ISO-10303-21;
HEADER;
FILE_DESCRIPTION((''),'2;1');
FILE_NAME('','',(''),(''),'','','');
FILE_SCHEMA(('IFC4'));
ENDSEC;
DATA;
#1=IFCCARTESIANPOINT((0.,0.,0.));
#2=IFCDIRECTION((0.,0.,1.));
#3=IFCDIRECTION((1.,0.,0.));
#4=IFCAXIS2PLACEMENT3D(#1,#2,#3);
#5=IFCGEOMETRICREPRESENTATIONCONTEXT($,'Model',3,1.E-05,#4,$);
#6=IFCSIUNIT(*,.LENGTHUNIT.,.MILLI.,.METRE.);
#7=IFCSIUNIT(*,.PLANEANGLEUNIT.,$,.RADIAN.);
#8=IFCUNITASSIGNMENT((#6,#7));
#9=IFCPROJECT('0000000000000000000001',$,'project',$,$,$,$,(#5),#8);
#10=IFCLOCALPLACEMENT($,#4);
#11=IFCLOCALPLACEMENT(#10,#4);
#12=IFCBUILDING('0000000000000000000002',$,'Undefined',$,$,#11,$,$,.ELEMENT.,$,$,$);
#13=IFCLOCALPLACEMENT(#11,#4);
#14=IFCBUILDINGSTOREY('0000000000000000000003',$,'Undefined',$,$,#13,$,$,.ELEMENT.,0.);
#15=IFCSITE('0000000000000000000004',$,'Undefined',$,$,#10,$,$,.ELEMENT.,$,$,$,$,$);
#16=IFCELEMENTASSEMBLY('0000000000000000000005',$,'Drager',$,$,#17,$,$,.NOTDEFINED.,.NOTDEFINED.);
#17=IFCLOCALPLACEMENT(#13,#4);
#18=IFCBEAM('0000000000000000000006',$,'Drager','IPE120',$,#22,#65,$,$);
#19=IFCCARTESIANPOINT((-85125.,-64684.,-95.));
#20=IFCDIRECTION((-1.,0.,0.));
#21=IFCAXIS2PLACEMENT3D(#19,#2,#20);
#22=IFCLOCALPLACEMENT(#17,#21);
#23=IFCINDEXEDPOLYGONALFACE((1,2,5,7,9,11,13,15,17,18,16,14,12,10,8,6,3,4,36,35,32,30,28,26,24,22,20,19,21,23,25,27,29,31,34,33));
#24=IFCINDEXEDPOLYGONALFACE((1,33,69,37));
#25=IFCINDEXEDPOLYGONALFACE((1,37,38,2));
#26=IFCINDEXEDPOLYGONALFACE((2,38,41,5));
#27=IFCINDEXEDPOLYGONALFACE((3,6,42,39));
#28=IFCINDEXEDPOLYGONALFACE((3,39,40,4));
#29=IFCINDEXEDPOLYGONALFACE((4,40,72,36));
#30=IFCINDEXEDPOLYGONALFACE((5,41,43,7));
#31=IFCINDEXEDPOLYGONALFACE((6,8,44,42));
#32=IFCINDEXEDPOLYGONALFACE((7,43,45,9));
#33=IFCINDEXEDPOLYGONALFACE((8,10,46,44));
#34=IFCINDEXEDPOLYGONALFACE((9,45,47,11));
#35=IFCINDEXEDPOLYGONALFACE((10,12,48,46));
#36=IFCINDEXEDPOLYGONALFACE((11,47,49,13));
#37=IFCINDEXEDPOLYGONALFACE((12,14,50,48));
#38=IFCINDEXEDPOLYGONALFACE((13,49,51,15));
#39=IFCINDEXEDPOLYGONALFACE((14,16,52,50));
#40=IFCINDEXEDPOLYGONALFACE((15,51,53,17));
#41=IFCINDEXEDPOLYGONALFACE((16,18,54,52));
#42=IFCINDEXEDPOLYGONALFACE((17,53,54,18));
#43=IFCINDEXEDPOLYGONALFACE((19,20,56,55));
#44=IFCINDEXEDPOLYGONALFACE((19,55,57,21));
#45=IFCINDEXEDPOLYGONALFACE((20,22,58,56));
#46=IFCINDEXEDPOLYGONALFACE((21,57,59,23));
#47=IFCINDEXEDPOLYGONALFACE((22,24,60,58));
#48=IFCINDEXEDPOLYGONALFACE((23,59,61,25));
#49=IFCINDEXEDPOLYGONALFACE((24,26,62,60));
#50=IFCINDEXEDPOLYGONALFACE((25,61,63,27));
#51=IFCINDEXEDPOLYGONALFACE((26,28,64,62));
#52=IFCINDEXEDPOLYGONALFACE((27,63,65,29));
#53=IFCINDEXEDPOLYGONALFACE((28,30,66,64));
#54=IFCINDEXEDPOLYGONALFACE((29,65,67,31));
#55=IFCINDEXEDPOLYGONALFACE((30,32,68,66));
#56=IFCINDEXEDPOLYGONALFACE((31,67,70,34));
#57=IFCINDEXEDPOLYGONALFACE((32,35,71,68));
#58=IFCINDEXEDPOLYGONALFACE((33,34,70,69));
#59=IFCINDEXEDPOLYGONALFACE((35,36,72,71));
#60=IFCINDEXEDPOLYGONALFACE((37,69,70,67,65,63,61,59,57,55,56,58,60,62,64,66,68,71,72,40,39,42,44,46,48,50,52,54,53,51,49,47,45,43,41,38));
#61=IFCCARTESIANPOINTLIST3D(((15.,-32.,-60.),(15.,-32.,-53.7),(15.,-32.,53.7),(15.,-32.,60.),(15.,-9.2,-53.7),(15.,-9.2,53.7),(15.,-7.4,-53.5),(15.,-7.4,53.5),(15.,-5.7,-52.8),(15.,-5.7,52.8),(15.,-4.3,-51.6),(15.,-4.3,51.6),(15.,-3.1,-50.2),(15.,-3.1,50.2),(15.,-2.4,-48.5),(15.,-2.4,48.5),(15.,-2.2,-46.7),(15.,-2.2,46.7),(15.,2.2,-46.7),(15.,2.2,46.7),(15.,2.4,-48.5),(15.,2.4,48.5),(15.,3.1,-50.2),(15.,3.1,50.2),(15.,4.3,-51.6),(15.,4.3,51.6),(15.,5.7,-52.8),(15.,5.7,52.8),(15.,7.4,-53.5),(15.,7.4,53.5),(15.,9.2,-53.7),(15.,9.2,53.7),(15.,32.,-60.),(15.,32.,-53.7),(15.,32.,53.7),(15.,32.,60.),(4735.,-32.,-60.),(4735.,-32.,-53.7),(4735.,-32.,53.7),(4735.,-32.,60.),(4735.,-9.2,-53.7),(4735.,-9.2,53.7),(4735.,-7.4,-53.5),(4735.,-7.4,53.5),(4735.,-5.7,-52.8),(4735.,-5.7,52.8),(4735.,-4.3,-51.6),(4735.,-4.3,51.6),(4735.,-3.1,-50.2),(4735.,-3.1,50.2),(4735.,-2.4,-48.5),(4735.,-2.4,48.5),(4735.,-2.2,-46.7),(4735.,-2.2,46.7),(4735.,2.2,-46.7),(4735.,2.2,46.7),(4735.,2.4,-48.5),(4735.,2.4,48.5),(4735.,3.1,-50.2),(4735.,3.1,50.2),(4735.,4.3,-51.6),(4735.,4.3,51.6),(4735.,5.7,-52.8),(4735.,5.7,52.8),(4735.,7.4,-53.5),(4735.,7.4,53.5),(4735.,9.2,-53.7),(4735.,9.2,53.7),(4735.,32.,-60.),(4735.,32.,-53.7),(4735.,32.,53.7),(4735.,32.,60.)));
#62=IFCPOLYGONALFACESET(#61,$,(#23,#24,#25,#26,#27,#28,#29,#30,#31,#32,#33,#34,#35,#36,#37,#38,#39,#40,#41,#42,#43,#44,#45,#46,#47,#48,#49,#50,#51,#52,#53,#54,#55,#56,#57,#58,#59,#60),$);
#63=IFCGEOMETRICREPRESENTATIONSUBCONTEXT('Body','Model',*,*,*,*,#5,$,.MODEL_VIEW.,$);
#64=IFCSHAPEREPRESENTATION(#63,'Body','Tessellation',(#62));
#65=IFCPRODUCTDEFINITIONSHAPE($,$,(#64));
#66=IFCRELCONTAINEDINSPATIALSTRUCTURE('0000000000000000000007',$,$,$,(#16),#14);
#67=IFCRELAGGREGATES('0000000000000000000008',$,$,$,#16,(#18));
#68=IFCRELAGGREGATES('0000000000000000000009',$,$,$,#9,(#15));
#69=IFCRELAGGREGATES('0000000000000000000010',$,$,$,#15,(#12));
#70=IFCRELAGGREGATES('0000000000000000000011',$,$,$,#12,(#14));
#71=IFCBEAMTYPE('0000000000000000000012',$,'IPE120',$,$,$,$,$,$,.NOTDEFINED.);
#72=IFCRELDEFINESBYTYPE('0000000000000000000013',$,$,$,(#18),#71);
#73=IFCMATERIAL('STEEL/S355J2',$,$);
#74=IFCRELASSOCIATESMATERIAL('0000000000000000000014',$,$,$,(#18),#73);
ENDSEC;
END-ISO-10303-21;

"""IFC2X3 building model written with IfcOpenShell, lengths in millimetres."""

from ifc_helpers import new_model, si_unit, frame, origin_with_axes, origin_2d_with_axis, place, context, subcontext, project, spatial, i_section, extrude, clip, halfspace, material, type_object, element, aggregate, save


model = new_model("IFC2X3")

# Units and contexts
model_context = context("Model", 3, precision=1e-05, world=origin_with_axes())
body_context = subcontext(model_context, "Body", "Model", "MODEL_VIEW")
ifc_project = project(units=[si_unit("LENGTHUNIT", "METRE", prefix="MILLI"), si_unit("PLANEANGLEUNIT", "RADIAN")], contexts=[model_context])

# Site, building, storey
site_placement = place(None, origin_with_axes())
site = spatial("IfcSite", under=ifc_project, at=site_placement, Name="Undefined", CompositionType="ELEMENT")
building_placement = place(site_placement, origin_with_axes())
building = spatial("IfcBuilding", under=site, at=building_placement, Name="Undefined", CompositionType="ELEMENT")
storey_placement = place(building_placement, origin_with_axes())
storey = spatial("IfcBuildingStorey", under=building, at=storey_placement, Name="Undefined", CompositionType="ELEMENT", Elevation=0.0)

# Shared definitions
ifc_material_1 = material(Name="STEEL/S355J2")

# Element assembly, beam
beam_type_1 = type_object("IfcBeamType", Name="IPE120", PredefinedType="NOTDEFINED")
assembly_1_placement = place(storey_placement, origin_with_axes())
assembly_1 = element("IfcElementAssembly", 1, at=assembly_1_placement, inside=storey, Name="Drager", AssemblyPlace="NOTDEFINED", PredefinedType="NOTDEFINED")
beam_1_placement = place(assembly_1_placement, frame((-85125.0, -64684.0, -95.0), z_axis=(0.0, 0.0, 1.0), x_axis=(-1.0, 0.0, 0.0)))
beam_1 = element("IfcBeam", 2, at=beam_1_placement, type_object=beam_type_1, material=ifc_material_1, Name="Drager", Description="IPE120", context=body_context, shape_type="Clipping", body=[
    clip(clip(extrude(i_section(OverallWidth=64.0, OverallDepth=120.0, WebThickness=4.4, FlangeThickness=6.3, FilletRadius=7.0, at=origin_2d_with_axis()), frame((4750.0, 0.0, 0.0), z_axis=(-1.0, 0.0, 0.0), x_axis=(0.0, -1.0, 0.0)), (0.0, 0.0, 1.0), 4750.0), halfspace(frame((4735.0, 0.0, -60.0), z_axis=(-1.0, 0.0, 0.0), x_axis=(0.0, 1.0, 0.0)), True)), halfspace(frame((15.0, 0.0, 60.0), z_axis=(1.0, 0.0, 0.0), x_axis=(0.0, 1.0, 0.0)), True)),
])

aggregate(assembly_1, [beam_1])

save(model, "model.ifc")
